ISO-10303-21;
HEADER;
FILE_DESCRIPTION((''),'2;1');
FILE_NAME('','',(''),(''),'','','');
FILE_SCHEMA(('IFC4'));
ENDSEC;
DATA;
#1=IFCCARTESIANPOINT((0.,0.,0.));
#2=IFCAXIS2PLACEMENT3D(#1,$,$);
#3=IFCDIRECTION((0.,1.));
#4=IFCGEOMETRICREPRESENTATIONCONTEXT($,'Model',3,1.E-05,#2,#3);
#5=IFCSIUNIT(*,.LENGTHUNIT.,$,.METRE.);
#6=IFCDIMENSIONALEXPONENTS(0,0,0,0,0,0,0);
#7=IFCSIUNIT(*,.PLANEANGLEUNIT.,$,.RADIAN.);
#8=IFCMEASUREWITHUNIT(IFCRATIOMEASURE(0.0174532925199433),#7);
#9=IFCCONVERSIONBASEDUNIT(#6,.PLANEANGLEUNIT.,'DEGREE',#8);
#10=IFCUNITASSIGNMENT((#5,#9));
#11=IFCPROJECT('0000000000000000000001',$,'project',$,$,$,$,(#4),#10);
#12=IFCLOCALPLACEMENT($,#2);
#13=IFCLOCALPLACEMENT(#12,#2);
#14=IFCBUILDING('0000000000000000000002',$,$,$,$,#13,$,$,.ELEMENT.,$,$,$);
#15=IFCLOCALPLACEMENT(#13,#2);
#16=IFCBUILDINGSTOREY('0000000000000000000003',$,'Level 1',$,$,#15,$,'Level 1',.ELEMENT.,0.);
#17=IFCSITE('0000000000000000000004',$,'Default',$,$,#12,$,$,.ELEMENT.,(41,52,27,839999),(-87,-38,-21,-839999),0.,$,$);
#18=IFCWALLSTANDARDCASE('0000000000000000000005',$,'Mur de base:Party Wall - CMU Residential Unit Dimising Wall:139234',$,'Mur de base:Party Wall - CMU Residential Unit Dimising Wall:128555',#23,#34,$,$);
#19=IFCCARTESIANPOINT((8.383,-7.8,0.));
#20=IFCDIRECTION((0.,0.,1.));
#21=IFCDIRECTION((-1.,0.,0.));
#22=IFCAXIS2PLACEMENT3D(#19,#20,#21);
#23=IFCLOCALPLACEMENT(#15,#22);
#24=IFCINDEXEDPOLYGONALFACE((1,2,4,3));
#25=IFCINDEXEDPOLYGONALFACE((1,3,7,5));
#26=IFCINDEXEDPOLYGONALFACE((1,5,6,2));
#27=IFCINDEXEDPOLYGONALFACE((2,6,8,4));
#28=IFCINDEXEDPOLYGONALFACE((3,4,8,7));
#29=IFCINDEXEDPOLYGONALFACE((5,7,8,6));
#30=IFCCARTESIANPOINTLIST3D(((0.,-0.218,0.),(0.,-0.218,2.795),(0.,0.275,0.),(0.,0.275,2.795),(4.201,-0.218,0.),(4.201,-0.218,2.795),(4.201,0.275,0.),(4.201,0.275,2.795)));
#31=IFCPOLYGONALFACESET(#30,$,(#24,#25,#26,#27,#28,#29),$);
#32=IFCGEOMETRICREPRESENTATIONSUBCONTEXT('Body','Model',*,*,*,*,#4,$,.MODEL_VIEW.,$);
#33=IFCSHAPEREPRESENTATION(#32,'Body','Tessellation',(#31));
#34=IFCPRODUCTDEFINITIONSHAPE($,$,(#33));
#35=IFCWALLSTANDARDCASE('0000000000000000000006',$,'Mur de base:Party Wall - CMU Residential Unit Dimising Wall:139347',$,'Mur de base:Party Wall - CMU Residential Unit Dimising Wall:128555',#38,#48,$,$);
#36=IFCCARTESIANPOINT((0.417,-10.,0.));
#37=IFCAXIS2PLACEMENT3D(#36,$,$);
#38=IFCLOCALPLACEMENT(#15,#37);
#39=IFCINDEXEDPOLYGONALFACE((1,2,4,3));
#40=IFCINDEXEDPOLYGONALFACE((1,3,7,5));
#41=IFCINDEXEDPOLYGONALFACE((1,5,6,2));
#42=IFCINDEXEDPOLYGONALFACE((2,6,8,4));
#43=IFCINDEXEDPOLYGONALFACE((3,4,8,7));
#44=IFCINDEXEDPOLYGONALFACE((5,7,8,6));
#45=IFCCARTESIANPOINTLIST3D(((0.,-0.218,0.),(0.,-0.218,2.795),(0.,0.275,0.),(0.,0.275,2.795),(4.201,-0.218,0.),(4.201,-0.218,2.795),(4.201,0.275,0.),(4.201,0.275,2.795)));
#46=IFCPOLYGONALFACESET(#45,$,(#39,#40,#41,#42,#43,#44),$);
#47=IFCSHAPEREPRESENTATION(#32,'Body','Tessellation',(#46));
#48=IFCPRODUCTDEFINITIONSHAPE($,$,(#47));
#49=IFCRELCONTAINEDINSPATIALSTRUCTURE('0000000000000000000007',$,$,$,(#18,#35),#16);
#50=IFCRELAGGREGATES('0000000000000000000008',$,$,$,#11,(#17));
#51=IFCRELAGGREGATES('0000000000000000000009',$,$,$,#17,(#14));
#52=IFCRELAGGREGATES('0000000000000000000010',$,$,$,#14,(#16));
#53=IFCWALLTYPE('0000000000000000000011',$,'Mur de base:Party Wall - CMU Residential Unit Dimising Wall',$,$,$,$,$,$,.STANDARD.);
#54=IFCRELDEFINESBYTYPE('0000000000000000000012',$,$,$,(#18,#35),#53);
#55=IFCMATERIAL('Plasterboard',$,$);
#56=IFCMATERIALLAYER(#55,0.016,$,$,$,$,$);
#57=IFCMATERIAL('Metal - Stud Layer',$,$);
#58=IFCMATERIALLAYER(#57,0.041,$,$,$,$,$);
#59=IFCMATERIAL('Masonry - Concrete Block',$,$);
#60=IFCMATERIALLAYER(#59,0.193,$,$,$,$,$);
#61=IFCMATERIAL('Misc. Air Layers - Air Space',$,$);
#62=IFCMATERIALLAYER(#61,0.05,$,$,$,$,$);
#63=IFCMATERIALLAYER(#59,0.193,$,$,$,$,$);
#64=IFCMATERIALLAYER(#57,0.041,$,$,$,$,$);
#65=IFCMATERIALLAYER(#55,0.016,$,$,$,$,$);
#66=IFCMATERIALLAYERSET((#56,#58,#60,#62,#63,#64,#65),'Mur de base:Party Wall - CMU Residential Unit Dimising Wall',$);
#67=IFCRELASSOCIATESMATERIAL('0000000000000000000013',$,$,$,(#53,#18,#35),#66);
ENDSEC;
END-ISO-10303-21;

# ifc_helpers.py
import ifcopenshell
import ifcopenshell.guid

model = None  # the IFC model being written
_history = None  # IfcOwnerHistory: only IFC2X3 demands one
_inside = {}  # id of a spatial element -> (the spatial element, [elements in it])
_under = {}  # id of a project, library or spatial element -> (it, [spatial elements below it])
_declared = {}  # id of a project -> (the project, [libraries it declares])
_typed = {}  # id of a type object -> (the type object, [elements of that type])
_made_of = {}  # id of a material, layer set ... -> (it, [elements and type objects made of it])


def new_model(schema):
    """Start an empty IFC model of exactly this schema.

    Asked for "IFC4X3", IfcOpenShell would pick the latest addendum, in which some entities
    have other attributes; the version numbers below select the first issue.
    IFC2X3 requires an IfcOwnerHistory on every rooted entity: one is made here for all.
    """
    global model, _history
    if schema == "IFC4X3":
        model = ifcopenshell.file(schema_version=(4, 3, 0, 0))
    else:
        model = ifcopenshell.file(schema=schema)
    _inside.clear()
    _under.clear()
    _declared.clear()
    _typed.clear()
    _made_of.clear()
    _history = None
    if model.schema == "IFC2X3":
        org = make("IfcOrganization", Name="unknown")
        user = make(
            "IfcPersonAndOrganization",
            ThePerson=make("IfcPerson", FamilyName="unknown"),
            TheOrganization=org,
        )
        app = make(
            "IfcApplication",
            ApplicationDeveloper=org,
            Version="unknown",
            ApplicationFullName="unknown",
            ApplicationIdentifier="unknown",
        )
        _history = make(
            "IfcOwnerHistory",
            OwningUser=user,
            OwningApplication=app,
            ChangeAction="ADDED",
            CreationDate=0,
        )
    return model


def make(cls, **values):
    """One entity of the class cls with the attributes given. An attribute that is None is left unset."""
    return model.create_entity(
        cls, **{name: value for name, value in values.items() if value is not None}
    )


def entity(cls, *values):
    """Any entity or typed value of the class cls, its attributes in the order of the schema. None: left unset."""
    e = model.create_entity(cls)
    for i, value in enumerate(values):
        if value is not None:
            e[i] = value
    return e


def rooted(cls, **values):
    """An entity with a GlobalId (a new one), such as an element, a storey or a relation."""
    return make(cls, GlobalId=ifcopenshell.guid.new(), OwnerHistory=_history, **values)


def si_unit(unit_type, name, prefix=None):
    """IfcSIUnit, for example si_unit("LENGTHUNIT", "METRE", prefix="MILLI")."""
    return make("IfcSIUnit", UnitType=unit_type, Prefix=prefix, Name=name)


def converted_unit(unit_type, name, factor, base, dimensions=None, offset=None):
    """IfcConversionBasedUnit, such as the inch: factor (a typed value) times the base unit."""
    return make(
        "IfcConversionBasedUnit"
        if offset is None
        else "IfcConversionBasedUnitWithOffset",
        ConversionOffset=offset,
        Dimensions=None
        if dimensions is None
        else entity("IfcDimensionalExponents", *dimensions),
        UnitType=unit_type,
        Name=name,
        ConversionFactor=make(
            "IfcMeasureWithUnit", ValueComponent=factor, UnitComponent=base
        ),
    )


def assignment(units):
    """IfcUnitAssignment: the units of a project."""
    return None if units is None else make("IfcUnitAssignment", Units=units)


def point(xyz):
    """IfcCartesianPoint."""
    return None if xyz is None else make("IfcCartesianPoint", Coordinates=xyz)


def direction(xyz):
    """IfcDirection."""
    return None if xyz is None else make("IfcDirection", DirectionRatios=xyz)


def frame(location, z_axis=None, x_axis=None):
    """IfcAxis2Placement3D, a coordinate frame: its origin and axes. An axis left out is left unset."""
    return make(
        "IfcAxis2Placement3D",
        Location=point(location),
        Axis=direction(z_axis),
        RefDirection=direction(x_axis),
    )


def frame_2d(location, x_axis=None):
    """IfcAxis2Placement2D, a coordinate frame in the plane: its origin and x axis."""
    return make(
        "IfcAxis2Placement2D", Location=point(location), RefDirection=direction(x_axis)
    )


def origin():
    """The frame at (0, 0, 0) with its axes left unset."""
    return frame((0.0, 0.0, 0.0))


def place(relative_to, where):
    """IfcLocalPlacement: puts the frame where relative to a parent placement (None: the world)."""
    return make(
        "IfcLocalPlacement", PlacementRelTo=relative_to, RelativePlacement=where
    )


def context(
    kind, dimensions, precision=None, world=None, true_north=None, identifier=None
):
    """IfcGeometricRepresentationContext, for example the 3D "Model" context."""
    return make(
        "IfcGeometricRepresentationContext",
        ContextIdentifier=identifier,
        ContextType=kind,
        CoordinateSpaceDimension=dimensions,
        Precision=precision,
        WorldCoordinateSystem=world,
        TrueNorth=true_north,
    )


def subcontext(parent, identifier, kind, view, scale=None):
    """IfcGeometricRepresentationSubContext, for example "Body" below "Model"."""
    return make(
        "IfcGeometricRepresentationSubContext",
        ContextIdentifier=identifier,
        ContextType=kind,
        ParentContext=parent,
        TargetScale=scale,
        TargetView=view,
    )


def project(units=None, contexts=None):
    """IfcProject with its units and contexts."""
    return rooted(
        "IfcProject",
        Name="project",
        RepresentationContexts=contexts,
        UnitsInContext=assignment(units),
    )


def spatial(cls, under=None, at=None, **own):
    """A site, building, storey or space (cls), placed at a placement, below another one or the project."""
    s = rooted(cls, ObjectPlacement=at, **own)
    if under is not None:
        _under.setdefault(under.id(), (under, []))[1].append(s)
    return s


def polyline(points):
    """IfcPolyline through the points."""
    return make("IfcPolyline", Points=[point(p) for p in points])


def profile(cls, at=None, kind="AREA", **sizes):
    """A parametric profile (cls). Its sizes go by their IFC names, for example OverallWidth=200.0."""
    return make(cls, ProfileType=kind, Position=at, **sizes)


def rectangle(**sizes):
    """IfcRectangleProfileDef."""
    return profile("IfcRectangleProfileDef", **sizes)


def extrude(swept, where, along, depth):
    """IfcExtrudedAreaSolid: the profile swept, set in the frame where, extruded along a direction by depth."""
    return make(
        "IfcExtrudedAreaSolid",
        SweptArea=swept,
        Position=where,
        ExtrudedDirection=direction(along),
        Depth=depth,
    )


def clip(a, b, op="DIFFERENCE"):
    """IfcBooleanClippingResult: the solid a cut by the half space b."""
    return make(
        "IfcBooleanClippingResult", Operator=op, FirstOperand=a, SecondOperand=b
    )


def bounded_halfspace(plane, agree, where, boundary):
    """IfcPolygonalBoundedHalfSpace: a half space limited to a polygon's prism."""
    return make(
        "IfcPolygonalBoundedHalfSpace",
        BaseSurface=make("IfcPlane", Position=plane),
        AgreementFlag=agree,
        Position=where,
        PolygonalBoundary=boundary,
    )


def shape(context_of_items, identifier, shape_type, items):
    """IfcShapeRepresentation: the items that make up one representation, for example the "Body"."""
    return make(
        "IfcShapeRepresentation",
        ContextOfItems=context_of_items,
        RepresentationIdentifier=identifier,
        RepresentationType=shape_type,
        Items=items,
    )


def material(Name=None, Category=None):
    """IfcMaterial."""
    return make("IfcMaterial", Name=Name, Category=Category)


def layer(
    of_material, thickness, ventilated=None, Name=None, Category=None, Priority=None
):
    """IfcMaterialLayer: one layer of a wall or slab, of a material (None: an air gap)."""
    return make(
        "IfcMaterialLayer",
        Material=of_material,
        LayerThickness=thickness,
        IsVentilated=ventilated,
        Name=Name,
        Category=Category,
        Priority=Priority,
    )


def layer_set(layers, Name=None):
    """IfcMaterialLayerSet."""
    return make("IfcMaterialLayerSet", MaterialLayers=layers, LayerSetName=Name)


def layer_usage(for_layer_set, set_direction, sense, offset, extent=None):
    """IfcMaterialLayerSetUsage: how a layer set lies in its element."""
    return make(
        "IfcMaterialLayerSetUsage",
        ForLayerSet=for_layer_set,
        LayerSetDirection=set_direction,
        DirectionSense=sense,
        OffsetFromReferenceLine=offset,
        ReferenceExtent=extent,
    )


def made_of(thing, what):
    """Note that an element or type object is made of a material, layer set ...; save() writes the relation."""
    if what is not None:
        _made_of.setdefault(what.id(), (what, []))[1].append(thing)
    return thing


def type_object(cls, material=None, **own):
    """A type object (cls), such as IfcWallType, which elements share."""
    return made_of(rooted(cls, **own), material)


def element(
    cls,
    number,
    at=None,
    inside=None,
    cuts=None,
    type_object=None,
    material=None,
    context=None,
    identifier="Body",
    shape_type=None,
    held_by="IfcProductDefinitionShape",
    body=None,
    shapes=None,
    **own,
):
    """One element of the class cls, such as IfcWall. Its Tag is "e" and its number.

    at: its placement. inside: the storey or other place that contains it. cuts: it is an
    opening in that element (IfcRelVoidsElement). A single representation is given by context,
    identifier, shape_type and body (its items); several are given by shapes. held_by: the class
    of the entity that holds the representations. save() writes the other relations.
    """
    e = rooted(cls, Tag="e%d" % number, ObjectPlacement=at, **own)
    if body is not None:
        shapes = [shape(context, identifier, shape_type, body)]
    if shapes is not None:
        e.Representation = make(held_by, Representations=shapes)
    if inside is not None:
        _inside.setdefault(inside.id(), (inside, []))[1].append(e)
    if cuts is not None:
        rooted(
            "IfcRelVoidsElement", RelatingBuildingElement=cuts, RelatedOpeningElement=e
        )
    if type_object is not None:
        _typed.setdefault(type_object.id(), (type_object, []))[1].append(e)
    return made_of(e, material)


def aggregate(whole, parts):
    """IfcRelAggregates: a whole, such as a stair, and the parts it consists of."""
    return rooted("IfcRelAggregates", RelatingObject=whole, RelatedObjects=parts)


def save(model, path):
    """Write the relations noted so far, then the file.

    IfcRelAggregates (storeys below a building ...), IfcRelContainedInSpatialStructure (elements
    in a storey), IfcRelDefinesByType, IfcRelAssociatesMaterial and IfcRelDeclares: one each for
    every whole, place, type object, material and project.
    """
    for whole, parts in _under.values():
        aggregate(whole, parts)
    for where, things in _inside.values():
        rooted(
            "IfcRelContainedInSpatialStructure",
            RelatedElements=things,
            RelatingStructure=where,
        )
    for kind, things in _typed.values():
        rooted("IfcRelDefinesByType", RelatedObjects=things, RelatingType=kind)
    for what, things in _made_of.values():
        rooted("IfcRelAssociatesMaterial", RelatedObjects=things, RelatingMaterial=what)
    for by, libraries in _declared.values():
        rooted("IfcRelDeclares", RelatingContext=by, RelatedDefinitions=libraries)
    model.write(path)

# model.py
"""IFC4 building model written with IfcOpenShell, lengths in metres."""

from ifc_helpers import new_model, entity, si_unit, converted_unit, direction, frame, frame_2d, origin, place, context, subcontext, project, spatial, polyline, rectangle, extrude, clip, bounded_halfspace, material, layer, layer_set, layer_usage, type_object, element, save


model = new_model("IFC4")

# Units and contexts
model_context = context("Model", 3, precision=1e-05, world=origin(), true_north=direction((0.0, 1.0)))
body_context = subcontext(model_context, "Body", "Model", "MODEL_VIEW")
ifc_project = project(units=[si_unit("LENGTHUNIT", "METRE"), converted_unit("PLANEANGLEUNIT", "DEGREE", entity("IfcRatioMeasure", 0.0174532925199433), si_unit("PLANEANGLEUNIT", "RADIAN"), dimensions=[0, 0, 0, 0, 0, 0, 0])], contexts=[model_context])

# Site, building, storey
site_placement = place(None, origin())
site = spatial("IfcSite", under=ifc_project, at=site_placement, Name="Default", CompositionType="ELEMENT", RefLatitude=(41, 52, 27, 839999), RefLongitude=(-87, -38, -21, -839999), RefElevation=0.0)
building_placement = place(site_placement, origin())
building = spatial("IfcBuilding", under=site, at=building_placement, CompositionType="ELEMENT")
storey_placement = place(building_placement, origin())
storey = spatial("IfcBuildingStorey", under=building, at=storey_placement, Name="Level 1", LongName="Level 1", CompositionType="ELEMENT", Elevation=0.0)

# Walls
ifc_material_1 = material(Name="Metal - Stud Layer")
ifc_material_2 = material(Name="Plasterboard")
ifc_layer_1 = layer(ifc_material_2, 0.016)
ifc_layer_2 = layer(ifc_material_1, 0.041)
ifc_material_3 = material(Name="Masonry - Concrete Block")
ifc_layer_3 = layer(ifc_material_3, 0.193)
ifc_material_4 = material(Name="Misc. Air Layers - Air Space")
ifc_layer_4 = layer(ifc_material_4, 0.05)
ifc_layer_5 = layer(ifc_material_3, 0.193)
ifc_layer_6 = layer(ifc_material_1, 0.041)
ifc_layer_7 = layer(ifc_material_2, 0.016)
ifc_layer_set_1 = layer_set([ifc_layer_1, ifc_layer_2, ifc_layer_3, ifc_layer_4, ifc_layer_5, ifc_layer_6, ifc_layer_7], Name="Mur de base:Party Wall - CMU Residential Unit Dimising Wall")
ifc_layer_usage_1 = layer_usage(ifc_layer_set_1, "AXIS2", "NEGATIVE", 0.275)
wall_type_1 = type_object("IfcWallType", Name="Mur de base:Party Wall - CMU Residential Unit Dimising Wall", PredefinedType="STANDARD", material=ifc_layer_set_1)
wall_1_placement = place(storey_placement, frame((8.383, -7.8, 0.0), z_axis=(0.0, 0.0, 1.0), x_axis=(-1.0, 0.0, 0.0)))
element("IfcWallStandardCase", 1, at=wall_1_placement, inside=storey, type_object=wall_type_1, material=ifc_layer_usage_1, Name="Mur de base:Party Wall - CMU Residential Unit Dimising Wall:139234", ObjectType="Mur de base:Party Wall - CMU Residential Unit Dimising Wall:128555", context=body_context, shape_type="Clipping", body=[
    clip(clip(extrude(rectangle(XDim=4.201, YDim=0.55, at=frame_2d((2.1005, 0.0), x_axis=(-1.0, 0.0))), origin(), (0.0, 0.0, 1.0), 2.795), bounded_halfspace(frame((0.0, -0.218, 2.795), z_axis=(0.0, 1.0, 0.0), x_axis=(-1.0, 0.0, 0.0)), True, frame((0.0, -0.218, 2.795), z_axis=(0.0, 1.0, 0.0), x_axis=(-1.0, 0.0, 0.0)), polyline([(0.0, 0.0), (-3.708, 0.0), (-4.201, 0.0), (-4.201, -2.795), (0.0, -2.795), (0.0, 0.0)]))), bounded_halfspace(frame((4.201, 0.275, 0.0), z_axis=(-1.0, 0.0, 0.0), x_axis=(0.0, -1.0, 0.0)), True, frame((4.201, 0.275, 0.0), z_axis=(-1.0, 0.0, 0.0), x_axis=(0.0, -1.0, 0.0)), polyline([(0.0, 0.0), (0.493, 0.0), (0.493, 2.795), (0.0, 2.795), (0.0, 0.0)]))),
])
ifc_layer_usage_2 = layer_usage(ifc_layer_set_1, "AXIS2", "NEGATIVE", 0.275)
wall_2_placement = place(storey_placement, frame((0.417, -10.0, 0.0)))
element("IfcWallStandardCase", 2, at=wall_2_placement, inside=storey, type_object=wall_type_1, material=ifc_layer_usage_2, Name="Mur de base:Party Wall - CMU Residential Unit Dimising Wall:139347", ObjectType="Mur de base:Party Wall - CMU Residential Unit Dimising Wall:128555", context=body_context, shape_type="Clipping", body=[
    clip(clip(extrude(rectangle(XDim=4.201, YDim=0.55, at=frame_2d((2.1005, 0.0), x_axis=(-1.0, 0.0))), origin(), (0.0, 0.0, 1.0), 2.795), bounded_halfspace(frame((0.0, -0.218, 0.0), z_axis=(0.0, 1.0, 0.0), x_axis=(-1.0, 0.0, 0.0)), True, frame((0.0, -0.218, 0.0), z_axis=(0.0, 1.0, 0.0), x_axis=(-1.0, 0.0, 0.0)), polyline([(0.0, 0.0), (0.0, 2.795), (-4.201, 2.795), (-4.201, 0.0), (0.0, 0.0)]))), bounded_halfspace(frame((4.201, 0.275, 0.0), z_axis=(-1.0, 0.0, 0.0), x_axis=(0.0, -1.0, 0.0)), True, frame((4.201, 0.275, 0.0), z_axis=(-1.0, 0.0, 0.0), x_axis=(0.0, -1.0, 0.0)), polyline([(0.0, 0.0), (0.493, 0.0), (0.493, 2.795), (0.0, 2.795), (0.0, 0.0)]))),
])

save(model, "model.ifc")
